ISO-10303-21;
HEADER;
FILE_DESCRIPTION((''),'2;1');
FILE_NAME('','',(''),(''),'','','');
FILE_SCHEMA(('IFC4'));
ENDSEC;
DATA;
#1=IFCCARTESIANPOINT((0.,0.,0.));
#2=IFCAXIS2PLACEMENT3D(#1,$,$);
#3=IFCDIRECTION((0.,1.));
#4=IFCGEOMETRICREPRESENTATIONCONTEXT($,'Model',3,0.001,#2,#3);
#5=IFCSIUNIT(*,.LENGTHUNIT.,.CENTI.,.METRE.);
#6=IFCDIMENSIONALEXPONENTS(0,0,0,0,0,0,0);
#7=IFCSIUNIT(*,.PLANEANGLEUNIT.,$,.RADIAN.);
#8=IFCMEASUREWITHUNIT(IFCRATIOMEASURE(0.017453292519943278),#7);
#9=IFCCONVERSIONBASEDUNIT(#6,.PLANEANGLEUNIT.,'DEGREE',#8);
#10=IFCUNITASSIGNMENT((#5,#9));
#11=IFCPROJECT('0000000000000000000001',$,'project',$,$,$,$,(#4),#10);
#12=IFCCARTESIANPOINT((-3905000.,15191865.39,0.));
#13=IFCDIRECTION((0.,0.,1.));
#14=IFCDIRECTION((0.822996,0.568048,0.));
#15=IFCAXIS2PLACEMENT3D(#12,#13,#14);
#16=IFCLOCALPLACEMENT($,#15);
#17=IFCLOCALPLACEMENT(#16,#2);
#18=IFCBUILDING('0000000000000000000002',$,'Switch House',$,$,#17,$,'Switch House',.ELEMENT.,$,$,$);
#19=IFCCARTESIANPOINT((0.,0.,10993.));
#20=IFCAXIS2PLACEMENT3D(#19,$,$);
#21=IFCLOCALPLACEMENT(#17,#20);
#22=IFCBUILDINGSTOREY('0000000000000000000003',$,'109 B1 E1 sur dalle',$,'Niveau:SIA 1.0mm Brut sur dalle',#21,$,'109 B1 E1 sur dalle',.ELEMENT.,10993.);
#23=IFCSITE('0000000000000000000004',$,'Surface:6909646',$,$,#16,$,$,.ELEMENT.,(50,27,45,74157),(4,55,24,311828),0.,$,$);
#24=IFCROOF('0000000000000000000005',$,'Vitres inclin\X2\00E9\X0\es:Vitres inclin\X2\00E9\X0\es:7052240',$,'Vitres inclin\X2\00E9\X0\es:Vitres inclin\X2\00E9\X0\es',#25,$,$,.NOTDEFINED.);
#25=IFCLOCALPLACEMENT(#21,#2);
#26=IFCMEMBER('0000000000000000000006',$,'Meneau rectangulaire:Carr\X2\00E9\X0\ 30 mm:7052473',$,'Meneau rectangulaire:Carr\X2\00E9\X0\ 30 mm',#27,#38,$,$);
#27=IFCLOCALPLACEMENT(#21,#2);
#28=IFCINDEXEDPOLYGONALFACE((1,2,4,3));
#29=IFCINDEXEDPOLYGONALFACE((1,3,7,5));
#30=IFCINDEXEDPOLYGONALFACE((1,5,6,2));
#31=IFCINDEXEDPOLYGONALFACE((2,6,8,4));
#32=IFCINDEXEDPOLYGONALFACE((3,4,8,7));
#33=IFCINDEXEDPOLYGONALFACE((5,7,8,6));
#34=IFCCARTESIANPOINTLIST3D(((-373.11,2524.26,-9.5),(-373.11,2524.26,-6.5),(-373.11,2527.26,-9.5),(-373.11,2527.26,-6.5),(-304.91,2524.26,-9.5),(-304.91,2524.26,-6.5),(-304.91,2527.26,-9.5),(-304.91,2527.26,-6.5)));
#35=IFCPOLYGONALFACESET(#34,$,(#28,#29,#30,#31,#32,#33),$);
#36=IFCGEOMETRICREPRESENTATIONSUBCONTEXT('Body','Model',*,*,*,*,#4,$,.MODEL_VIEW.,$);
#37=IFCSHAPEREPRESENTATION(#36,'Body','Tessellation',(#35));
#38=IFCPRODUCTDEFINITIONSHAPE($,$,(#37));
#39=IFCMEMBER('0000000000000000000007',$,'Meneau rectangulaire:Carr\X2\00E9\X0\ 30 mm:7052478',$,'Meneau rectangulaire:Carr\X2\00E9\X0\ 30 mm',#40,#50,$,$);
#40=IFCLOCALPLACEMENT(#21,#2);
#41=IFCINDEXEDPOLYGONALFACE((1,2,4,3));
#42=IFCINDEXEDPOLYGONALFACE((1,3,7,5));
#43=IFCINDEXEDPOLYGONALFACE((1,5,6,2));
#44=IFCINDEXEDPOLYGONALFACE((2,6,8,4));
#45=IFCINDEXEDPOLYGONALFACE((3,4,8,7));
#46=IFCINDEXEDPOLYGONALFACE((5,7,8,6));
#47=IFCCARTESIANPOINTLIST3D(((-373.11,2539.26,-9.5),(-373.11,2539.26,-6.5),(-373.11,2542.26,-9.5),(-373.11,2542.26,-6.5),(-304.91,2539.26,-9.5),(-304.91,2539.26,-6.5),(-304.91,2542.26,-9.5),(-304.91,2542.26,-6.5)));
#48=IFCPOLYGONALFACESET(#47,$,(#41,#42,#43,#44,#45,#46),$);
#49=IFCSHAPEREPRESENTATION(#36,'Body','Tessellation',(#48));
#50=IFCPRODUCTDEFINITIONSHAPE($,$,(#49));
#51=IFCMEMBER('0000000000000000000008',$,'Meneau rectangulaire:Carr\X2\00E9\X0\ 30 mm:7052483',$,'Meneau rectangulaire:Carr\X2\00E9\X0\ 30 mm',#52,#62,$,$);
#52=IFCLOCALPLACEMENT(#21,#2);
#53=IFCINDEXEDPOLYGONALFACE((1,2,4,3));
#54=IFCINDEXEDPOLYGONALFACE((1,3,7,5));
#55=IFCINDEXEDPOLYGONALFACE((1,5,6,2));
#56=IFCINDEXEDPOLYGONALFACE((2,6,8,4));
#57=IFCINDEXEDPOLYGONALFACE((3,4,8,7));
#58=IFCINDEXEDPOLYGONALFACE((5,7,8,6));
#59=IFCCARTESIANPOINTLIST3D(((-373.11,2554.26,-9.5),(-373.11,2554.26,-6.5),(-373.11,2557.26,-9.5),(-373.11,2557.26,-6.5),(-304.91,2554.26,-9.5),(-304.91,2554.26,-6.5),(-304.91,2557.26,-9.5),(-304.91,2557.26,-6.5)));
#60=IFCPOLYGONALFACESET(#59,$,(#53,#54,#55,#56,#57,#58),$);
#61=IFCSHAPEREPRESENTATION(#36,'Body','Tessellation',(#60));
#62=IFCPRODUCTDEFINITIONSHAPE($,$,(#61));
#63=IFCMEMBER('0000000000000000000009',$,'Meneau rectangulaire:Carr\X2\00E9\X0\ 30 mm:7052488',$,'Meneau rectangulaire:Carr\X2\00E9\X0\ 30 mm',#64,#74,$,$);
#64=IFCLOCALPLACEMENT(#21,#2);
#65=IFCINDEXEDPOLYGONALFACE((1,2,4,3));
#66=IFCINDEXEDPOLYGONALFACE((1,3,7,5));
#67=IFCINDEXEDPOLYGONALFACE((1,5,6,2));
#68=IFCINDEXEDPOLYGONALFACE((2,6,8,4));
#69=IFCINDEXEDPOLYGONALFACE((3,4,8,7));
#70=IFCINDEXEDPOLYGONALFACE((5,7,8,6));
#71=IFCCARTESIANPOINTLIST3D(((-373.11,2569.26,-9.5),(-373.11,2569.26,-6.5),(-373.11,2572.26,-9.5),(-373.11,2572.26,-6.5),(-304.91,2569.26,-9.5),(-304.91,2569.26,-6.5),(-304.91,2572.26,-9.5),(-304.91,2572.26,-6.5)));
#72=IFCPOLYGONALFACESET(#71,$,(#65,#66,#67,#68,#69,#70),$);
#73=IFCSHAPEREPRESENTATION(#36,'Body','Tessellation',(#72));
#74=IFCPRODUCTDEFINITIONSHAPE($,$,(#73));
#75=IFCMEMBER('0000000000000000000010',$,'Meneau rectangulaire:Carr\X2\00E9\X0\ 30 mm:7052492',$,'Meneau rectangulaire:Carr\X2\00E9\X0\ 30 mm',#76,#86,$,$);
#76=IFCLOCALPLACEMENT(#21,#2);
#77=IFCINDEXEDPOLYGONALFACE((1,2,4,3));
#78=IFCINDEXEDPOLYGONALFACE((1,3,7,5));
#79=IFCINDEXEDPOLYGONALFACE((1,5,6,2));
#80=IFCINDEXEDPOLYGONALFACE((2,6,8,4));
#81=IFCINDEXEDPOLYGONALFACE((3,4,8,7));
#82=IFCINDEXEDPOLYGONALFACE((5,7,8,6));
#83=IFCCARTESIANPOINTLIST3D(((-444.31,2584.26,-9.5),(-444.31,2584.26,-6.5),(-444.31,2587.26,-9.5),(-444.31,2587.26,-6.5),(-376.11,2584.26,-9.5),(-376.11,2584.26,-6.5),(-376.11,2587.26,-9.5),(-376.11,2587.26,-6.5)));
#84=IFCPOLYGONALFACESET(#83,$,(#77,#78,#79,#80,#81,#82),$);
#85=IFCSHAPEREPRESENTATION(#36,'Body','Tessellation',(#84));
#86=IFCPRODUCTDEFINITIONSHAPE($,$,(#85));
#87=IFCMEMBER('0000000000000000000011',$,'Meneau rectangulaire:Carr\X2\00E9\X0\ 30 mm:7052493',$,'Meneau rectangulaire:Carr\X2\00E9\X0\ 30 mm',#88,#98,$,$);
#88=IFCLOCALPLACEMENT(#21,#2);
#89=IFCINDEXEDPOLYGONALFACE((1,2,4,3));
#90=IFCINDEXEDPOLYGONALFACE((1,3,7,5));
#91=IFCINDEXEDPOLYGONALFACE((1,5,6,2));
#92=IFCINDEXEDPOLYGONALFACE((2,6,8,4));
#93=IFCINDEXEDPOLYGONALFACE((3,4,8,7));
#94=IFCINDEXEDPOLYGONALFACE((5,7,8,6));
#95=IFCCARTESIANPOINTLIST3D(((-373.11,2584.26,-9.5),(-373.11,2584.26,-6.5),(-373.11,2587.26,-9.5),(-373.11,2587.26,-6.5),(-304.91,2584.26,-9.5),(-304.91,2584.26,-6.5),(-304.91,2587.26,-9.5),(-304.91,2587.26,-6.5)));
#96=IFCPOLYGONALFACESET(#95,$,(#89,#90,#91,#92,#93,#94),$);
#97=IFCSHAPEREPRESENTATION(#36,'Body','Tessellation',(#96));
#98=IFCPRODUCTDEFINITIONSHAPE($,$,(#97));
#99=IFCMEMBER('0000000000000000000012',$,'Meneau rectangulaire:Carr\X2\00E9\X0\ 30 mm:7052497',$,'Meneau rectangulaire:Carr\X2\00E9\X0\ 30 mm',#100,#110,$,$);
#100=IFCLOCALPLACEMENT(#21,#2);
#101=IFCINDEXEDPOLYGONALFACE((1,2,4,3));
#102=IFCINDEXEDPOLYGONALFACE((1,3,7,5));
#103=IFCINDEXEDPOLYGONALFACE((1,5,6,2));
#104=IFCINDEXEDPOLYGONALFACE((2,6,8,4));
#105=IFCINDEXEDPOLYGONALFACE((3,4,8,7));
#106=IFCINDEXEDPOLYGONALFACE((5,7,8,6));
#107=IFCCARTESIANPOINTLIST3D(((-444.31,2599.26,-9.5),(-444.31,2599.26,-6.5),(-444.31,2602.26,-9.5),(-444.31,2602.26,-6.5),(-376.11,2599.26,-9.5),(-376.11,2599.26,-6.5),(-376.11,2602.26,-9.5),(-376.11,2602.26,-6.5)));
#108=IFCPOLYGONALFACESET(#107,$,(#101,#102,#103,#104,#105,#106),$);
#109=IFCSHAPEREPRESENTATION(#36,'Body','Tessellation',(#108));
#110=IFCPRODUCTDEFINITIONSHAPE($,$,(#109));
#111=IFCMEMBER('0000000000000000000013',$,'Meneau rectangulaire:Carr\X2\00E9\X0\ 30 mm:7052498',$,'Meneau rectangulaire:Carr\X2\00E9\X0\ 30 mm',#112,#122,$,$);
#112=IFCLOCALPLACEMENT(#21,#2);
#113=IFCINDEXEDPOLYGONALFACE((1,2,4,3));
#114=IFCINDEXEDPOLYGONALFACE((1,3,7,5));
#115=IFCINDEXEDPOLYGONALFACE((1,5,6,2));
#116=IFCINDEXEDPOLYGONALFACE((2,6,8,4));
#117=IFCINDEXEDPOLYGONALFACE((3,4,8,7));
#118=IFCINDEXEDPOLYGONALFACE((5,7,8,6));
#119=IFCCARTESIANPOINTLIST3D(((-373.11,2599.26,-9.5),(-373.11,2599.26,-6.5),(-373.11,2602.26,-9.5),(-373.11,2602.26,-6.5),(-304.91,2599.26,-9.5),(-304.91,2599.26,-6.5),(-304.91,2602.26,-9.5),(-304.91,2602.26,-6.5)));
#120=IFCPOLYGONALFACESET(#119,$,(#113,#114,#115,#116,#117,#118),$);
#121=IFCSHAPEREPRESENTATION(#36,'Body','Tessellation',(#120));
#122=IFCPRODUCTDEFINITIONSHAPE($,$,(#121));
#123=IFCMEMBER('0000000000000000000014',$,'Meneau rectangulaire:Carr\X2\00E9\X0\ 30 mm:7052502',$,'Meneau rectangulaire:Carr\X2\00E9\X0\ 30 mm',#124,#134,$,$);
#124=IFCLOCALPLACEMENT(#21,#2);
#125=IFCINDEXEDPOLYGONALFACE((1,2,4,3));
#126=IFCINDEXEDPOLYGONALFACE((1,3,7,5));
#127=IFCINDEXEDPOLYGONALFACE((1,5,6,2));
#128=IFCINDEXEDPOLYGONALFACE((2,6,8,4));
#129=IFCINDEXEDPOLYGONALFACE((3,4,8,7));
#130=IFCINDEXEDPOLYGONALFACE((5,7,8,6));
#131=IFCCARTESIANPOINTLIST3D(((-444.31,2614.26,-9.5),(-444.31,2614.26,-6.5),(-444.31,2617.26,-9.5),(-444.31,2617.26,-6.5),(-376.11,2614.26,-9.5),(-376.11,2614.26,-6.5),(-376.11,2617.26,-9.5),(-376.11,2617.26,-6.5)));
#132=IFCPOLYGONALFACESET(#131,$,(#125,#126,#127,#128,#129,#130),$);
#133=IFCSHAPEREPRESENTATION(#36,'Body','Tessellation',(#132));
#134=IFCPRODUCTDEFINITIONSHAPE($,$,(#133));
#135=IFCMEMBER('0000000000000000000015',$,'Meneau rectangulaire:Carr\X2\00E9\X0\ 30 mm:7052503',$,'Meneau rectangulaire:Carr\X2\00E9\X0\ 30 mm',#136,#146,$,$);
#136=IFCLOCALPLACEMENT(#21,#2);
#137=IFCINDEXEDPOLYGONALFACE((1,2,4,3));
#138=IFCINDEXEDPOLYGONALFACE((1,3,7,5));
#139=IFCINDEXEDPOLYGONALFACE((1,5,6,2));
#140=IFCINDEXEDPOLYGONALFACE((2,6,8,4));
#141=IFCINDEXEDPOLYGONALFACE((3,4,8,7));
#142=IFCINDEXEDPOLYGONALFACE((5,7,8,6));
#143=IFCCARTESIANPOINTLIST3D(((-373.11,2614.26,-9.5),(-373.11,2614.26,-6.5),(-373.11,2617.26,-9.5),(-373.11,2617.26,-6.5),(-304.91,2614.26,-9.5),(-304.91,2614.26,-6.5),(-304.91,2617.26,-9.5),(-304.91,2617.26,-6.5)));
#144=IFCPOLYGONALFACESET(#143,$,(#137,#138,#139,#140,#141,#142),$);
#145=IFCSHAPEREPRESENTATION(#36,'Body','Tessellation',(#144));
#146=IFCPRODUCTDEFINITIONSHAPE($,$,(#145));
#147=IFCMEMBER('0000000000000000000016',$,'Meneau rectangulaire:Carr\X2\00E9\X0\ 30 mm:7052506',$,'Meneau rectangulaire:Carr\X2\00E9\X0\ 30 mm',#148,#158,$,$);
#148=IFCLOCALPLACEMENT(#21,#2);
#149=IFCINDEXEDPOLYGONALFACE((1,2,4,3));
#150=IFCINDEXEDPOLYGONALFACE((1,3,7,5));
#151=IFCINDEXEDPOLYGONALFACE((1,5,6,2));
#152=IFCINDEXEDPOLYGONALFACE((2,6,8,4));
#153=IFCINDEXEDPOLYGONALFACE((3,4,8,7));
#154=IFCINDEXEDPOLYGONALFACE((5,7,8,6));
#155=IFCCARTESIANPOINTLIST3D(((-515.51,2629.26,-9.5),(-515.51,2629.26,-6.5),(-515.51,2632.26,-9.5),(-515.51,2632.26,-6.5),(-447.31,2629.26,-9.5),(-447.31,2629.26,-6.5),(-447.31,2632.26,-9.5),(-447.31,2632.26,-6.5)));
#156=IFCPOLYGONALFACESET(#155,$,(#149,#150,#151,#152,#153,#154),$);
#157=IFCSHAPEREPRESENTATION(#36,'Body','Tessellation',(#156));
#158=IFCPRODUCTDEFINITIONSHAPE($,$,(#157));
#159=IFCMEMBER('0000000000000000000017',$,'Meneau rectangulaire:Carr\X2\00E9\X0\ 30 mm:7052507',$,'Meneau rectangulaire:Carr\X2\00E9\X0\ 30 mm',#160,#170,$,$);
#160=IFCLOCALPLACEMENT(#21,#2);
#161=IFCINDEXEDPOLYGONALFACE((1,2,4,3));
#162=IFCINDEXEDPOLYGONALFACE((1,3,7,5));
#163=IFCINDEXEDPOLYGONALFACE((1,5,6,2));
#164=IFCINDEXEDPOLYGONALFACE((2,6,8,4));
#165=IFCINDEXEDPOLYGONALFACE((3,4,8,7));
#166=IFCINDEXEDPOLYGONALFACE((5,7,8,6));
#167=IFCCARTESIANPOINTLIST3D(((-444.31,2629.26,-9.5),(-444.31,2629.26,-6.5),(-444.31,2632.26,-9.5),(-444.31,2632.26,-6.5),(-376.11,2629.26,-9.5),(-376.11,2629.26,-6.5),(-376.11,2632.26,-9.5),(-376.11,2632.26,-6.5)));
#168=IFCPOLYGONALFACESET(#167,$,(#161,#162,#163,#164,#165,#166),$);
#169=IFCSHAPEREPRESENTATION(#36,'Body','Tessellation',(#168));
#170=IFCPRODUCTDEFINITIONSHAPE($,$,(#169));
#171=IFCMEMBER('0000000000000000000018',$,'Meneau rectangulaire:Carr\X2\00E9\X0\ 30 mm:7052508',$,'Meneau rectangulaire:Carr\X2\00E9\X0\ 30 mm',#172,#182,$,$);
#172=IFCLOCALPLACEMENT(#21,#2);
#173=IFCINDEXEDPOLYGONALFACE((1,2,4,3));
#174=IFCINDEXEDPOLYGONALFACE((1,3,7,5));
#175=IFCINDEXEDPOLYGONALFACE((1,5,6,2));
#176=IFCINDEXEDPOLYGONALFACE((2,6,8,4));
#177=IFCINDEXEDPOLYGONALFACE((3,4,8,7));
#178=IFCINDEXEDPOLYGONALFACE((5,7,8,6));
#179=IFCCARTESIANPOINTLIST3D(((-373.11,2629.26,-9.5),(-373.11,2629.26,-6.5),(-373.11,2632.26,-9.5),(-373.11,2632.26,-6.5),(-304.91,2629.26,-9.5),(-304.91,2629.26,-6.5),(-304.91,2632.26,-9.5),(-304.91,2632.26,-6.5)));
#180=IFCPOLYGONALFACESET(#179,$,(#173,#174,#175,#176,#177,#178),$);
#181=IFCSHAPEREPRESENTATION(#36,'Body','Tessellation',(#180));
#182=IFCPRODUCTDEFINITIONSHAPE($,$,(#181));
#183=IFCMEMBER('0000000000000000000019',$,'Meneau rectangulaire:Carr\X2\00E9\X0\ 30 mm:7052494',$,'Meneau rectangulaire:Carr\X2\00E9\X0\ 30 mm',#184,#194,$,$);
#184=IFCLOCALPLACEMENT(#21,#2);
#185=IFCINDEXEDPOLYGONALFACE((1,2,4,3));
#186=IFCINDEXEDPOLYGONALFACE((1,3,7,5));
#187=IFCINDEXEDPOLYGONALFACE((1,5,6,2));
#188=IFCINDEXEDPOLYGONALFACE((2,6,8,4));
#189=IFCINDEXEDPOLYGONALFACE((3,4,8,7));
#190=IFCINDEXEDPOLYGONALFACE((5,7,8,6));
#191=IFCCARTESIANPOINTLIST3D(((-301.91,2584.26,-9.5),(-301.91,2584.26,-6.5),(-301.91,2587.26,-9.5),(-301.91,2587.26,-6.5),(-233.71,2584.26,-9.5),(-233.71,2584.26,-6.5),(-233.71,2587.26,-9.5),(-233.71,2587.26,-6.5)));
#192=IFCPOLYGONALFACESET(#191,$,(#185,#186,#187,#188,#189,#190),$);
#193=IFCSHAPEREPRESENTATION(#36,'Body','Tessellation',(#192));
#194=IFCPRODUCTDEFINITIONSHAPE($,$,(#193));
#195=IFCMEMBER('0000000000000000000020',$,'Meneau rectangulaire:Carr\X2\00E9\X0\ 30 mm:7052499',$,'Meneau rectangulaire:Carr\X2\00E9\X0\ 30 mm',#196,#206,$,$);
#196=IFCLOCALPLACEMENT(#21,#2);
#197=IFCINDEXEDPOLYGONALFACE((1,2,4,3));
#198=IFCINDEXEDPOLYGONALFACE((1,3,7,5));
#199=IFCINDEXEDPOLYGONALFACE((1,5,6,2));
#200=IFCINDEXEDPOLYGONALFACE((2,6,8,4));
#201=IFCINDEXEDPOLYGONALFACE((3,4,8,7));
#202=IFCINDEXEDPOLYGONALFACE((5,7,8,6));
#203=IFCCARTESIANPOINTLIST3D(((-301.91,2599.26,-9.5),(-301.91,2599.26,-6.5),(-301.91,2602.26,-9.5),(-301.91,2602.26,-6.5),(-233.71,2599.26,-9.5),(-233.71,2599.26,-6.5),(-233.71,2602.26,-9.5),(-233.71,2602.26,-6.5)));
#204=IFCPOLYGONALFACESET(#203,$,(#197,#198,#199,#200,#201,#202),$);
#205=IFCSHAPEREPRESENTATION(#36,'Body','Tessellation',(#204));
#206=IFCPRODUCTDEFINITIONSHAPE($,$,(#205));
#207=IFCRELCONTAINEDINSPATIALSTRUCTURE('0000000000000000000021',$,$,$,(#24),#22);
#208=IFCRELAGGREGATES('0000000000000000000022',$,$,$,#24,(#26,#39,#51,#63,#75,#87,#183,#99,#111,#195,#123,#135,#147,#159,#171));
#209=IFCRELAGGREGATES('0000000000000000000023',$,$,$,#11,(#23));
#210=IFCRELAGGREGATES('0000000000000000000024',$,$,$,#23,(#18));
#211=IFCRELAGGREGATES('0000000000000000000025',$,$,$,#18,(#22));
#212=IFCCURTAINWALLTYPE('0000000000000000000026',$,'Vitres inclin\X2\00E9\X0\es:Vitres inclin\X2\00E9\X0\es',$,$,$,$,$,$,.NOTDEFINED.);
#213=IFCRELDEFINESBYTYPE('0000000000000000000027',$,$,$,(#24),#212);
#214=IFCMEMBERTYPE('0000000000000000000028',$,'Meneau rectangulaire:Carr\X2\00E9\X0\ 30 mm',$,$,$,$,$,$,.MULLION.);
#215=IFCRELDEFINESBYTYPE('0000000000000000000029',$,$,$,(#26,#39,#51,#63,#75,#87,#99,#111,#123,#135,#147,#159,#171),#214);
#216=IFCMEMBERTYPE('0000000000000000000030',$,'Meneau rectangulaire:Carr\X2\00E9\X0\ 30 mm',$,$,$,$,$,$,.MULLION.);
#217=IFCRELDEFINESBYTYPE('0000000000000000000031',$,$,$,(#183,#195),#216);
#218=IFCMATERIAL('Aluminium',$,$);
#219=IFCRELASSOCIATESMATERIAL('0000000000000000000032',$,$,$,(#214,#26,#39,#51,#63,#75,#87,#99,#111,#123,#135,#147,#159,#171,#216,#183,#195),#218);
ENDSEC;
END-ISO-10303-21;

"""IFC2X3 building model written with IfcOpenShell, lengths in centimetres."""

from ifc_helpers import new_model, entity, si_unit, converted_unit, direction, frame, origin, origin_2d_with_axis, place, context, subcontext, project, spatial, rectangle, extrude, source, transform, mapped, material, type_object, type_shapes, element, aggregate, save


model = new_model("IFC2X3")

# Units and contexts
model_context = context("Model", 3, precision=0.001, world=origin(), true_north=direction((0.0, 1.0)))
body_context = subcontext(model_context, "Body", "Model", "MODEL_VIEW")
ifc_project = project(units=[si_unit("LENGTHUNIT", "METRE", prefix="CENTI"), converted_unit("PLANEANGLEUNIT", "DEGREE", entity("IfcRatioMeasure", 0.017453292519943278), si_unit("PLANEANGLEUNIT", "RADIAN"), dimensions=[0, 0, 0, 0, 0, 0, 0])], contexts=[model_context])

# Site, building, storey
site_placement = place(None, frame((-3905000.0, 15191865.39, 0.0), z_axis=(0.0, 0.0, 1.0), x_axis=(0.822996, 0.568048, 0.0)))
site = spatial("IfcSite", under=ifc_project, at=site_placement, Name="Surface:6909646", CompositionType="ELEMENT", RefLatitude=(50, 27, 45, 74157), RefLongitude=(4, 55, 24, 311828), RefElevation=0.0)
building_placement = place(site_placement, origin())
building = spatial("IfcBuilding", under=site, at=building_placement, Name="Switch House", LongName="Switch House", CompositionType="ELEMENT")
storey_placement = place(building_placement, frame((0.0, 0.0, 10993.0)))
storey = spatial("IfcBuildingStorey", under=building, at=storey_placement, Name="109 B1 E1 sur dalle", ObjectType="Niveau:SIA 1.0mm Brut sur dalle", LongName="109 B1 E1 sur dalle", CompositionType="ELEMENT", Elevation=10993.0)

# Roof, members
curtain_wall_type = type_object("IfcCurtainWallType", Name="Vitres inclinées:Vitres inclinées", PredefinedType="NOTDEFINED")
roof_placement = place(storey_placement, frame((0.0, 0.0, -10993.0)))
roof = element("IfcRoof", 1, at=roof_placement, inside=storey, type_object=curtain_wall_type, Name="Vitres inclinées:Vitres inclinées:7052240", ObjectType="Vitres inclinées:Vitres inclinées", ShapeType="NOTDEFINED")
ifc_material = material(Name="Aluminium")
member_type_1 = type_object("IfcMemberType", Name="Meneau rectangulaire:Carré 30 mm", PredefinedType="MULLION", material=ifc_material)
shared_shape_1 = source(origin(), body_context, "Body", "SweptSolid", [
    extrude(rectangle(XDim=3.0, YDim=3.0, at=origin_2d_with_axis()), frame((0.0, 0.0, -68.2), z_axis=(0.0, 0.0, 1.0), x_axis=(0.0, -1.0, 0.0)), (0.0, 0.0, 1.0), 68.2),
])
type_shapes(member_type_1, [shared_shape_1])
member_1_placement = place(roof_placement, frame((-373.11, 2525.76, 10985.0), z_axis=(-1.0, 0.0, 0.0), x_axis=(0.0, 1.0, 0.0)))
member_1 = element("IfcMember", 2, at=member_1_placement, type_object=member_type_1, material=ifc_material, Name="Meneau rectangulaire:Carré 30 mm:7052473", ObjectType="Meneau rectangulaire:Carré 30 mm", context=body_context, shape_type="MappedRepresentation", body=[
    mapped(shared_shape_1, transform((0.0, 0.0, 0.0), scale=1.0)),
])
member_2_placement = place(roof_placement, frame((-373.11, 2540.76, 10985.0), z_axis=(-1.0, 0.0, 0.0), x_axis=(0.0, 1.0, 0.0)))
member_2 = element("IfcMember", 3, at=member_2_placement, type_object=member_type_1, material=ifc_material, Name="Meneau rectangulaire:Carré 30 mm:7052478", ObjectType="Meneau rectangulaire:Carré 30 mm", context=body_context, shape_type="MappedRepresentation", body=[
    mapped(shared_shape_1, transform((0.0, 0.0, 0.0), scale=1.0)),
])
member_3_placement = place(roof_placement, frame((-373.11, 2555.76, 10985.0), z_axis=(-1.0, 0.0, 0.0), x_axis=(0.0, 1.0, 0.0)))
member_3 = element("IfcMember", 4, at=member_3_placement, type_object=member_type_1, material=ifc_material, Name="Meneau rectangulaire:Carré 30 mm:7052483", ObjectType="Meneau rectangulaire:Carré 30 mm", context=body_context, shape_type="MappedRepresentation", body=[
    mapped(shared_shape_1, transform((0.0, 0.0, 0.0), scale=1.0)),
])
member_4_placement = place(roof_placement, frame((-373.11, 2570.76, 10985.0), z_axis=(-1.0, 0.0, 0.0), x_axis=(0.0, 1.0, 0.0)))
member_4 = element("IfcMember", 5, at=member_4_placement, type_object=member_type_1, material=ifc_material, Name="Meneau rectangulaire:Carré 30 mm:7052488", ObjectType="Meneau rectangulaire:Carré 30 mm", context=body_context, shape_type="MappedRepresentation", body=[
    mapped(shared_shape_1, transform((0.0, 0.0, 0.0), scale=1.0)),
])
member_5_placement = place(roof_placement, frame((-444.31, 2585.76, 10985.0), z_axis=(-1.0, 0.0, 0.0), x_axis=(0.0, 1.0, 0.0)))
member_5 = element("IfcMember", 6, at=member_5_placement, type_object=member_type_1, material=ifc_material, Name="Meneau rectangulaire:Carré 30 mm:7052492", ObjectType="Meneau rectangulaire:Carré 30 mm", context=body_context, shape_type="MappedRepresentation", body=[
    mapped(shared_shape_1, transform((0.0, 0.0, 0.0), scale=1.0)),
])
member_6_placement = place(roof_placement, frame((-373.11, 2585.76, 10985.0), z_axis=(-1.0, 0.0, 0.0), x_axis=(0.0, 1.0, 0.0)))
member_6 = element("IfcMember", 7, at=member_6_placement, type_object=member_type_1, material=ifc_material, Name="Meneau rectangulaire:Carré 30 mm:7052493", ObjectType="Meneau rectangulaire:Carré 30 mm", context=body_context, shape_type="MappedRepresentation", body=[
    mapped(shared_shape_1, transform((0.0, 0.0, 0.0), scale=1.0)),
])
member_7_placement = place(roof_placement, frame((-444.31, 2600.76, 10985.0), z_axis=(-1.0, 0.0, 0.0), x_axis=(0.0, 1.0, 0.0)))
member_7 = element("IfcMember", 8, at=member_7_placement, type_object=member_type_1, material=ifc_material, Name="Meneau rectangulaire:Carré 30 mm:7052497", ObjectType="Meneau rectangulaire:Carré 30 mm", context=body_context, shape_type="MappedRepresentation", body=[
    mapped(shared_shape_1, transform((0.0, 0.0, 0.0), scale=1.0)),
])
member_8_placement = place(roof_placement, frame((-373.11, 2600.76, 10985.0), z_axis=(-1.0, 0.0, 0.0), x_axis=(0.0, 1.0, 0.0)))
member_8 = element("IfcMember", 9, at=member_8_placement, type_object=member_type_1, material=ifc_material, Name="Meneau rectangulaire:Carré 30 mm:7052498", ObjectType="Meneau rectangulaire:Carré 30 mm", context=body_context, shape_type="MappedRepresentation", body=[
    mapped(shared_shape_1, transform((0.0, 0.0, 0.0), scale=1.0)),
])
member_9_placement = place(roof_placement, frame((-444.31, 2615.76, 10985.0), z_axis=(-1.0, 0.0, 0.0), x_axis=(0.0, 1.0, 0.0)))
member_9 = element("IfcMember", 10, at=member_9_placement, type_object=member_type_1, material=ifc_material, Name="Meneau rectangulaire:Carré 30 mm:7052502", ObjectType="Meneau rectangulaire:Carré 30 mm", context=body_context, shape_type="MappedRepresentation", body=[
    mapped(shared_shape_1, transform((0.0, 0.0, 0.0), scale=1.0)),
])
member_10_placement = place(roof_placement, frame((-373.11, 2615.76, 10985.0), z_axis=(-1.0, 0.0, 0.0), x_axis=(0.0, 1.0, 0.0)))
member_10 = element("IfcMember", 11, at=member_10_placement, type_object=member_type_1, material=ifc_material, Name="Meneau rectangulaire:Carré 30 mm:7052503", ObjectType="Meneau rectangulaire:Carré 30 mm", context=body_context, shape_type="MappedRepresentation", body=[
    mapped(shared_shape_1, transform((0.0, 0.0, 0.0), scale=1.0)),
])
member_11_placement = place(roof_placement, frame((-515.51, 2630.76, 10985.0), z_axis=(-1.0, 0.0, 0.0), x_axis=(0.0, 1.0, 0.0)))
member_11 = element("IfcMember", 12, at=member_11_placement, type_object=member_type_1, material=ifc_material, Name="Meneau rectangulaire:Carré 30 mm:7052506", ObjectType="Meneau rectangulaire:Carré 30 mm", context=body_context, shape_type="MappedRepresentation", body=[
    mapped(shared_shape_1, transform((0.0, 0.0, 0.0), scale=1.0)),
])
member_12_placement = place(roof_placement, frame((-444.31, 2630.76, 10985.0), z_axis=(-1.0, 0.0, 0.0), x_axis=(0.0, 1.0, 0.0)))
member_12 = element("IfcMember", 13, at=member_12_placement, type_object=member_type_1, material=ifc_material, Name="Meneau rectangulaire:Carré 30 mm:7052507", ObjectType="Meneau rectangulaire:Carré 30 mm", context=body_context, shape_type="MappedRepresentation", body=[
    mapped(shared_shape_1, transform((0.0, 0.0, 0.0), scale=1.0)),
])
member_13_placement = place(roof_placement, frame((-373.11, 2630.76, 10985.0), z_axis=(-1.0, 0.0, 0.0), x_axis=(0.0, 1.0, 0.0)))
member_13 = element("IfcMember", 14, at=member_13_placement, type_object=member_type_1, material=ifc_material, Name="Meneau rectangulaire:Carré 30 mm:7052508", ObjectType="Meneau rectangulaire:Carré 30 mm", context=body_context, shape_type="MappedRepresentation", body=[
    mapped(shared_shape_1, transform((0.0, 0.0, 0.0), scale=1.0)),
])
member_type_2 = type_object("IfcMemberType", Name="Meneau rectangulaire:Carré 30 mm", PredefinedType="MULLION", material=ifc_material)
shared_shape_2 = source(origin(), body_context, "Body", "SweptSolid", [
    extrude(rectangle(XDim=3.0, YDim=3.0, at=origin_2d_with_axis()), frame((0.0, 0.0, -68.2), z_axis=(0.0, 0.0, 1.0), x_axis=(0.0, -1.0, 0.0)), (0.0, 0.0, 1.0), 68.2),
])
type_shapes(member_type_2, [shared_shape_2])
member_14_placement = place(roof_placement, frame((-301.91, 2585.76, 10985.0), z_axis=(-1.0, 0.0, 0.0), x_axis=(0.0, 1.0, 0.0)))
member_14 = element("IfcMember", 15, at=member_14_placement, type_object=member_type_2, material=ifc_material, Name="Meneau rectangulaire:Carré 30 mm:7052494", ObjectType="Meneau rectangulaire:Carré 30 mm", context=body_context, shape_type="MappedRepresentation", body=[
    mapped(shared_shape_2, transform((0.0, 0.0, 0.0), scale=1.0)),
])
member_15_placement = place(roof_placement, frame((-301.91, 2600.76, 10985.0), z_axis=(-1.0, 0.0, 0.0), x_axis=(0.0, 1.0, 0.0)))
member_15 = element("IfcMember", 16, at=member_15_placement, type_object=member_type_2, material=ifc_material, Name="Meneau rectangulaire:Carré 30 mm:7052499", ObjectType="Meneau rectangulaire:Carré 30 mm", context=body_context, shape_type="MappedRepresentation", body=[
    mapped(shared_shape_2, transform((0.0, 0.0, 0.0), scale=1.0)),
])
aggregate(roof, [member_1, member_2, member_3, member_4, member_5, member_6, member_14, member_7, member_8, member_15, member_9, member_10, member_11, member_12, member_13])

save(model, "model.ifc")
